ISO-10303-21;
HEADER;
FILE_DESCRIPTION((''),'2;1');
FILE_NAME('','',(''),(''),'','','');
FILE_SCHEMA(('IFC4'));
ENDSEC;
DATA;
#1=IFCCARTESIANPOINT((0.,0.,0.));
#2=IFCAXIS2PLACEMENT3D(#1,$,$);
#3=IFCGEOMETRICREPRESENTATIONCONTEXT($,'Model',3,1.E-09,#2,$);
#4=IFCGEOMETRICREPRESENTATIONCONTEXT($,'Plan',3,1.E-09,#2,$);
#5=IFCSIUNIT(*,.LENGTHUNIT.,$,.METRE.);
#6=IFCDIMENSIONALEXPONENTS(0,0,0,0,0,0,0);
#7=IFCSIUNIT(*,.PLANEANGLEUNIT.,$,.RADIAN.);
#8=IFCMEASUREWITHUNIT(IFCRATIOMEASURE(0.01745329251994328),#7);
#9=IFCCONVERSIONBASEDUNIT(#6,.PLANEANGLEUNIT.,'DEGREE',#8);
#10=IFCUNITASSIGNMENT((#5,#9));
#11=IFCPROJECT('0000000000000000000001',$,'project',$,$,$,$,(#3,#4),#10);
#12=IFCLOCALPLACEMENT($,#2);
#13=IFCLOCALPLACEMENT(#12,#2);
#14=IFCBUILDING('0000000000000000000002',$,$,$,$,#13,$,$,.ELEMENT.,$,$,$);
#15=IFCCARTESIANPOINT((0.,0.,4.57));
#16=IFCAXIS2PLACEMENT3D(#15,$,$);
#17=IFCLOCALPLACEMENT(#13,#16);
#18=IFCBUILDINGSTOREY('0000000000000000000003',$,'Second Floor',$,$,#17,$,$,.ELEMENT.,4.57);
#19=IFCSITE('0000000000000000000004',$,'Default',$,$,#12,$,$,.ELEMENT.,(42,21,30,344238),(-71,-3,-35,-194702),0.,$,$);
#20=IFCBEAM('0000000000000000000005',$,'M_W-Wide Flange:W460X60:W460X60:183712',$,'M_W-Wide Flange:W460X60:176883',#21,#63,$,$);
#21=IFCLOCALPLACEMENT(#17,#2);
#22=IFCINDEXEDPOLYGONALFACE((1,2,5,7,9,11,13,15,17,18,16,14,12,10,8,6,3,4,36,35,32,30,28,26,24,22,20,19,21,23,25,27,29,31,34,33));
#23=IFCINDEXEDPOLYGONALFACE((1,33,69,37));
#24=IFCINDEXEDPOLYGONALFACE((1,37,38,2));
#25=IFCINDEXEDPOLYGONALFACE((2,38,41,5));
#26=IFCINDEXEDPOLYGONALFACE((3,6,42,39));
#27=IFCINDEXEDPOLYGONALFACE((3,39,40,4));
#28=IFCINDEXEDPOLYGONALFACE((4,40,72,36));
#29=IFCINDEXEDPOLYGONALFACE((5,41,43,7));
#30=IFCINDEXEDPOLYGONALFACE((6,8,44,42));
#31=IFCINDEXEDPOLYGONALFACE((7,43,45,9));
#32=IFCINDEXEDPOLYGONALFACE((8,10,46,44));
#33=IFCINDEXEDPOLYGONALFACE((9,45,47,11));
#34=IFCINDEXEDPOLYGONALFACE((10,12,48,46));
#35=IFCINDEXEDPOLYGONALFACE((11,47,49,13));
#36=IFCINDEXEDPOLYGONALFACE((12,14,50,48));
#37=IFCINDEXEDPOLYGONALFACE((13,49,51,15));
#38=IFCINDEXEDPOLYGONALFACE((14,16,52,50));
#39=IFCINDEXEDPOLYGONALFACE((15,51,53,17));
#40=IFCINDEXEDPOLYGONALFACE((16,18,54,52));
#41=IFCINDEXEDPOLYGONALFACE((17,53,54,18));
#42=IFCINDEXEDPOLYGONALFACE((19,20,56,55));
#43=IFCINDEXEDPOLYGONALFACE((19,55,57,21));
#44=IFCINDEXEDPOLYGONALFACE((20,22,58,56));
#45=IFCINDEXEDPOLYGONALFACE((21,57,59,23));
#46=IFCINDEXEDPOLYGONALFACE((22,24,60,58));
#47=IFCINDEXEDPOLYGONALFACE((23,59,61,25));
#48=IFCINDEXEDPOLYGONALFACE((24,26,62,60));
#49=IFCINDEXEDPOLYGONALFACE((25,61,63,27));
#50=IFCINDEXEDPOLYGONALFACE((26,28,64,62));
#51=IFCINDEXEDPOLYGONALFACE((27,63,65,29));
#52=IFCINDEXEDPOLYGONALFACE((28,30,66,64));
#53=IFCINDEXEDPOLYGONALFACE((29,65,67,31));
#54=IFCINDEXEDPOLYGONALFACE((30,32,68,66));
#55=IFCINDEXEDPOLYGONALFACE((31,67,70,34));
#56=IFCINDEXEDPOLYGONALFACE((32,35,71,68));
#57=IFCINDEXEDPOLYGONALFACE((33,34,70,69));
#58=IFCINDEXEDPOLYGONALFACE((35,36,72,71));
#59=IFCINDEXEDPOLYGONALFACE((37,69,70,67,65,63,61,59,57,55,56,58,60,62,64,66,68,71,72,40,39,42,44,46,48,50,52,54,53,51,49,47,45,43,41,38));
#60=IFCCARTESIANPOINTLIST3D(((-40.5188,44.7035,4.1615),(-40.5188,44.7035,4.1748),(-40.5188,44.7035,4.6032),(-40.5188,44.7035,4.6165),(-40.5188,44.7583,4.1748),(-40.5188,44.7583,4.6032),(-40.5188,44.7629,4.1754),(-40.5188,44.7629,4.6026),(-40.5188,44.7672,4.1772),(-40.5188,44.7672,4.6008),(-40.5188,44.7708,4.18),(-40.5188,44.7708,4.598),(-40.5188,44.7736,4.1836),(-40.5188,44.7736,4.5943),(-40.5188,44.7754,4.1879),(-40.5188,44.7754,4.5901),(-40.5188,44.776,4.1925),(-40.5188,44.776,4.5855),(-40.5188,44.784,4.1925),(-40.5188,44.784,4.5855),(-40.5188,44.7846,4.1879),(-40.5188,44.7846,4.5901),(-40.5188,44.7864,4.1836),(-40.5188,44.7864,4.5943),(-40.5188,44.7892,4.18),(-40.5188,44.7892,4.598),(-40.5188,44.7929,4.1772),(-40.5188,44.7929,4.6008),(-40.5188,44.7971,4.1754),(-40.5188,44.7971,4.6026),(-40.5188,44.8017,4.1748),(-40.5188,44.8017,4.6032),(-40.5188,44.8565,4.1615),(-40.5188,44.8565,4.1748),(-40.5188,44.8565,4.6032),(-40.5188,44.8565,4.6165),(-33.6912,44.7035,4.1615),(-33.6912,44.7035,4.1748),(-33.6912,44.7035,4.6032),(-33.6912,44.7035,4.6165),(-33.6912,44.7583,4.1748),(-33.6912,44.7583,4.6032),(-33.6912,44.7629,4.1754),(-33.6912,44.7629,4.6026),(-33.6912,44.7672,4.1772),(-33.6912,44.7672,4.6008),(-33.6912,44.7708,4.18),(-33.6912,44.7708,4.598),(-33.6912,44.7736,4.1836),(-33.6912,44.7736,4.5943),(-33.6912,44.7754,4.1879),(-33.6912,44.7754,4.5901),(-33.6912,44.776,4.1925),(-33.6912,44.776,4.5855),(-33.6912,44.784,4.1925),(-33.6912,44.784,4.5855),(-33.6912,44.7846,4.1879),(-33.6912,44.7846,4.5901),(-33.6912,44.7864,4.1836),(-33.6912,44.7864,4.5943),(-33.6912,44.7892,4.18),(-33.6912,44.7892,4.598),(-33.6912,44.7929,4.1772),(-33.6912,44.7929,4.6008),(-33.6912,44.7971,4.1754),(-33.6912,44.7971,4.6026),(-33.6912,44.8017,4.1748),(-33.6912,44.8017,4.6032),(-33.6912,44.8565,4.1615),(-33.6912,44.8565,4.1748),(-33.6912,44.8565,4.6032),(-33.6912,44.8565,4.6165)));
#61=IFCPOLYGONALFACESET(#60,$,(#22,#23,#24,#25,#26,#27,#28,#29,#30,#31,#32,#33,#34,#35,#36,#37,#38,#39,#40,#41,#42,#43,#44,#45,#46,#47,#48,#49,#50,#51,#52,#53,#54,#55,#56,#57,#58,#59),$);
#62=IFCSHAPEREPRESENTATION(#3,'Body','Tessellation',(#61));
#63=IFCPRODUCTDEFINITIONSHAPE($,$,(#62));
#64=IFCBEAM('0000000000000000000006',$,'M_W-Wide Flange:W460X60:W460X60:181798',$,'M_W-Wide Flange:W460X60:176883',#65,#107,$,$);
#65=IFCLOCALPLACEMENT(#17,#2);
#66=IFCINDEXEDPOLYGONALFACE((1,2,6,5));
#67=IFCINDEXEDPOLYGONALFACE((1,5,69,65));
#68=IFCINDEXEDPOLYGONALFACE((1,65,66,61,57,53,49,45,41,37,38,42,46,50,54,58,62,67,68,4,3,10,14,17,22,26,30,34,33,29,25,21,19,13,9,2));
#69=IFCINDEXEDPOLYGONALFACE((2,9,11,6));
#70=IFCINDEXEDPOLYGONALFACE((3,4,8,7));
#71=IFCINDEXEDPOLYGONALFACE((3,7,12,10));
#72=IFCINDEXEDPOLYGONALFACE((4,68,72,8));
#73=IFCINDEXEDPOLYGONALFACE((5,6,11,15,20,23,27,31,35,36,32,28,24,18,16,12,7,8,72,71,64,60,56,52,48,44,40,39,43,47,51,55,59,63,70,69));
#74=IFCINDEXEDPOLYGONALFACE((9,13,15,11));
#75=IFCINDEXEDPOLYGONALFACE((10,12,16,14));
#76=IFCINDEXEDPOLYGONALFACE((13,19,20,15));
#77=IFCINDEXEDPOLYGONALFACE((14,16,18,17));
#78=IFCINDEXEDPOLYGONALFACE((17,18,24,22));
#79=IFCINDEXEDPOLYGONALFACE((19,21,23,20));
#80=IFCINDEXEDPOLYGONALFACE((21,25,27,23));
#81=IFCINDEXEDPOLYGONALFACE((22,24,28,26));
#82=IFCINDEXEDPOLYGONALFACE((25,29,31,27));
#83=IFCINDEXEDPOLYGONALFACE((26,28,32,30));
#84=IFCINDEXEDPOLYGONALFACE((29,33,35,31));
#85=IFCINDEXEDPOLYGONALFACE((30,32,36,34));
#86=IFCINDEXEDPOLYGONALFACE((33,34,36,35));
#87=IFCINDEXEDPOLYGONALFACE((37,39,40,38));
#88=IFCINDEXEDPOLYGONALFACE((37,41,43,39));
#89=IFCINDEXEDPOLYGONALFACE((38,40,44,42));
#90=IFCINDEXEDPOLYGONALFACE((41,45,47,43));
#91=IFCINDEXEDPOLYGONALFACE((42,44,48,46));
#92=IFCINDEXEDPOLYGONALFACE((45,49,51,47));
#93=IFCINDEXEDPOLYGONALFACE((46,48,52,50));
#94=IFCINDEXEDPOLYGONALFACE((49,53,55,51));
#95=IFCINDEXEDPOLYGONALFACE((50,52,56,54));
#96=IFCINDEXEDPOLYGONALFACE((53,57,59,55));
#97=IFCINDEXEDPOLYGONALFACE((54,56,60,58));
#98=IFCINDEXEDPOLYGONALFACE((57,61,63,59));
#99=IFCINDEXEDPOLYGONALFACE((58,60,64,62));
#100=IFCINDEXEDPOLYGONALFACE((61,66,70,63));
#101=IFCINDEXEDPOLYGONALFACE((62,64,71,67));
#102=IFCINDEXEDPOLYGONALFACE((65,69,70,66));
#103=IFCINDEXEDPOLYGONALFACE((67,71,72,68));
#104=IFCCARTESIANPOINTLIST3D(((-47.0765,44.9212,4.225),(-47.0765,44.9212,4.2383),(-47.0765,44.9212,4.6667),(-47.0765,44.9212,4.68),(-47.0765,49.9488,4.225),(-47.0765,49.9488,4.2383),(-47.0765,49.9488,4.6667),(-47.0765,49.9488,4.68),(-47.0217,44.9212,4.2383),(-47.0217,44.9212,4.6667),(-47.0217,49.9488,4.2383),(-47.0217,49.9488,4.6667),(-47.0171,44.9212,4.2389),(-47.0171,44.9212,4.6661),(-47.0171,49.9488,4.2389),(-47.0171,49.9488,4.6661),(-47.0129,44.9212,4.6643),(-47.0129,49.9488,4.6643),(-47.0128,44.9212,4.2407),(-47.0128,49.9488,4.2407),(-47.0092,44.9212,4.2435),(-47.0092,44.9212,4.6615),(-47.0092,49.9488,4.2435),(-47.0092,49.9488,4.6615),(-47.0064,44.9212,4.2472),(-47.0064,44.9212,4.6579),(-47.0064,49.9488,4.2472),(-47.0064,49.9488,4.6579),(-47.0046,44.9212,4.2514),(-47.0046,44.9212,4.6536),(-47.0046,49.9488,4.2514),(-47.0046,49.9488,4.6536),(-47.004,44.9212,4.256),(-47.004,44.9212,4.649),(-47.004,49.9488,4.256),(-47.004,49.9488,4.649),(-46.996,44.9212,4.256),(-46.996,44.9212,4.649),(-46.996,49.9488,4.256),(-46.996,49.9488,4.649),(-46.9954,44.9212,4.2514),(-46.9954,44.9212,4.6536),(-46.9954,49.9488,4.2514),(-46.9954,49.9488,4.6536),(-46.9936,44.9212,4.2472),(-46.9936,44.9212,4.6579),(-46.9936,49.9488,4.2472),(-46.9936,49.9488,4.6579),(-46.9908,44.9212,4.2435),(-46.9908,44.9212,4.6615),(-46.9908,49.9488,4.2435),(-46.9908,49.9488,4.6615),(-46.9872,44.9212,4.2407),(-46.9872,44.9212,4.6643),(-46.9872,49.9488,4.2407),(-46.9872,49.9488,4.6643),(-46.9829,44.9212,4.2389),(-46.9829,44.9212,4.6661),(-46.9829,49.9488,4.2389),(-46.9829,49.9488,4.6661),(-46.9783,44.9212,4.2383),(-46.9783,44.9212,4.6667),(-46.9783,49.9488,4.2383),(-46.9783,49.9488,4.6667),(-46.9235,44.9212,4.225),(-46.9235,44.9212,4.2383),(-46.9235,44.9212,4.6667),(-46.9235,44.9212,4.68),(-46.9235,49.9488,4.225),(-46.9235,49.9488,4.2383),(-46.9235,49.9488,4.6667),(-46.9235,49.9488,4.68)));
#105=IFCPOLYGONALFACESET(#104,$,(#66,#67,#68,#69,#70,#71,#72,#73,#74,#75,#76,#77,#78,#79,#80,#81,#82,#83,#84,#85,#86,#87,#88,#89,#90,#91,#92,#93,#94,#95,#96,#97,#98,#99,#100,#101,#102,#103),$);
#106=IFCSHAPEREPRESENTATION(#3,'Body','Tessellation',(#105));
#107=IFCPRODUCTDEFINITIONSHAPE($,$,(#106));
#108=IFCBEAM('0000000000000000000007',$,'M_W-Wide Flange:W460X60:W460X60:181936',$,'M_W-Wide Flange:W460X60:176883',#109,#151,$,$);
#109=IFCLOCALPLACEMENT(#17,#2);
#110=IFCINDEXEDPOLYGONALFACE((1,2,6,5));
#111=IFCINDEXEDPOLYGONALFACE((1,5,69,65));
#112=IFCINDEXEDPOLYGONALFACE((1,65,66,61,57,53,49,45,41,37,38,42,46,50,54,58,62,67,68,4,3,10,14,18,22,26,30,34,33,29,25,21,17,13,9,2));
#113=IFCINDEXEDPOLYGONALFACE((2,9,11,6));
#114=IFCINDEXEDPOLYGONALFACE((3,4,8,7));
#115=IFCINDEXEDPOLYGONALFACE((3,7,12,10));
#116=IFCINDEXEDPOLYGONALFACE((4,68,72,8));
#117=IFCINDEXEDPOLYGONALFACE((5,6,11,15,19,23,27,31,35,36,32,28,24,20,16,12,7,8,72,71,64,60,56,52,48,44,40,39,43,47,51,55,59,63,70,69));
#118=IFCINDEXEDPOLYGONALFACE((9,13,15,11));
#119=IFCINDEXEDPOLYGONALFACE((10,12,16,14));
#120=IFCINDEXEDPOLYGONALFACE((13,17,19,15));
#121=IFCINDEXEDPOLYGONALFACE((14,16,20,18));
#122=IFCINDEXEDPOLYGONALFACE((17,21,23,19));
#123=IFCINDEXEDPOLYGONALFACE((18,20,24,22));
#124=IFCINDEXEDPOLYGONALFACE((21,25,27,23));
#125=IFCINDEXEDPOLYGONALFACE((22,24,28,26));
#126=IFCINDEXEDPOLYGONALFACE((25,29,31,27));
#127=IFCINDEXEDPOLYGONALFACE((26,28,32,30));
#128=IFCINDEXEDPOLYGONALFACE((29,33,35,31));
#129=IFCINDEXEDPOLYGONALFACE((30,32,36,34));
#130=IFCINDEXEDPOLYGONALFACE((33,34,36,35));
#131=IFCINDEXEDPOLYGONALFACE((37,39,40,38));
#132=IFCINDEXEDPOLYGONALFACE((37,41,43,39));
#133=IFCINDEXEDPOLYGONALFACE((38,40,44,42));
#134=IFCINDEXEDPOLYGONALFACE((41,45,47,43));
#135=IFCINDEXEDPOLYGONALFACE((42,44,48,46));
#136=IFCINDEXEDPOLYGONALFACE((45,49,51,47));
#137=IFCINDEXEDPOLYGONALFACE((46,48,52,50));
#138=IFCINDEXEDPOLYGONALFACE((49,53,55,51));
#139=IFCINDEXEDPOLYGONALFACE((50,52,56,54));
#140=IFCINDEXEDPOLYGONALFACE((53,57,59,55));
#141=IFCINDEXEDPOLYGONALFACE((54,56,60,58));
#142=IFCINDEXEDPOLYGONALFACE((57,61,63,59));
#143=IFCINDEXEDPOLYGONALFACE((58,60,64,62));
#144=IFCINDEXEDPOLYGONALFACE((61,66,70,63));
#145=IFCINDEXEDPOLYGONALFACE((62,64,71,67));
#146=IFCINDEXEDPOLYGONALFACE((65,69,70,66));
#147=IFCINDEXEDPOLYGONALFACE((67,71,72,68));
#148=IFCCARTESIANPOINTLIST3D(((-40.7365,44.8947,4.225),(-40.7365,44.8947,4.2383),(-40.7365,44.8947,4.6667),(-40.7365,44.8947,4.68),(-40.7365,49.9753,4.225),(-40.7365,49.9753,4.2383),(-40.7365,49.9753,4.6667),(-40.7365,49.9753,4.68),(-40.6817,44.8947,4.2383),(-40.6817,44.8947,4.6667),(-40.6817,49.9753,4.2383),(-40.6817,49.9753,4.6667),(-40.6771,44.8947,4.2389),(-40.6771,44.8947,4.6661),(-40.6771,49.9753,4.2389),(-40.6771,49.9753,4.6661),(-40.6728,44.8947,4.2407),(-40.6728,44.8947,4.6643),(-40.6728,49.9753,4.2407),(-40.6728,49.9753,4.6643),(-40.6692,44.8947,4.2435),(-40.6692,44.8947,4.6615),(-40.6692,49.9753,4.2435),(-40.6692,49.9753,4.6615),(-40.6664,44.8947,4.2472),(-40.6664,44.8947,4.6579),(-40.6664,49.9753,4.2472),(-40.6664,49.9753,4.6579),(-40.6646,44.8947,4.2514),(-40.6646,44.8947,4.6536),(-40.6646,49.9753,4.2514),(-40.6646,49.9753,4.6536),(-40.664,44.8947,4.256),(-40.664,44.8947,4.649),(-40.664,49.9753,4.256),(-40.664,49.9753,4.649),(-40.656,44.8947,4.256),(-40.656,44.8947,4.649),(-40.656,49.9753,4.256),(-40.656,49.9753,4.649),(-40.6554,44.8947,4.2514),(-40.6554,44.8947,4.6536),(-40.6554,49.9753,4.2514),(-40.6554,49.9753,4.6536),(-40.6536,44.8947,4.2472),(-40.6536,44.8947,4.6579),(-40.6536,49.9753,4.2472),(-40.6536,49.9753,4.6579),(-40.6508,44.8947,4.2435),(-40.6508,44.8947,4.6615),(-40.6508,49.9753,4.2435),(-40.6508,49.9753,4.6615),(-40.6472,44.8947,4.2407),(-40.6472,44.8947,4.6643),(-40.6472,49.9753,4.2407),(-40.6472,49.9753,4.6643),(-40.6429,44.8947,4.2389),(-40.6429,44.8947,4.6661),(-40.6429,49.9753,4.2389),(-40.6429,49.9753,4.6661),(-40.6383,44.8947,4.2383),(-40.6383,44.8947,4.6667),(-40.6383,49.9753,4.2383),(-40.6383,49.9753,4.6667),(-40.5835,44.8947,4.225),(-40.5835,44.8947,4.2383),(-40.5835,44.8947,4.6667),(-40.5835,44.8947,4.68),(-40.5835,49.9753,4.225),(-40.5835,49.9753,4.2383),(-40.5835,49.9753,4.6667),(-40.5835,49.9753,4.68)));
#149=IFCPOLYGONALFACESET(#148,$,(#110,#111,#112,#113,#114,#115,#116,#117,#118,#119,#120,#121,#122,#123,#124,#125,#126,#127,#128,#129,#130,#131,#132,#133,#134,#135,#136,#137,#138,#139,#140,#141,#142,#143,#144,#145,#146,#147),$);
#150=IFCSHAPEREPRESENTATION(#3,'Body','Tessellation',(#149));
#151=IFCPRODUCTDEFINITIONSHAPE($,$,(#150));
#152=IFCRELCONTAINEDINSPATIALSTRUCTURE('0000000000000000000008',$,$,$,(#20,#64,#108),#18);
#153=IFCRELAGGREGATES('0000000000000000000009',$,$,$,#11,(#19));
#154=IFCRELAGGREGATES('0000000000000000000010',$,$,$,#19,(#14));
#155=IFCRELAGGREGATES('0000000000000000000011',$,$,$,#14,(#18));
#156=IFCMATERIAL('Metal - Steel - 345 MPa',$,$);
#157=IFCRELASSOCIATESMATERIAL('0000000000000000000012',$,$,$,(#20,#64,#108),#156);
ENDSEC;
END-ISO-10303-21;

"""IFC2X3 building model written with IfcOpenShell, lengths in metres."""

from ifc_helpers import new_model, entity, si_unit, converted_unit, frame, frame_2d, origin, place, context, project, spatial, polyline, circle_curve, parameter, trimmed, segment, composite_curve, outline, extrude, material, element, save


model = new_model("IFC2X3")

# Units and contexts
model_context = context("Model", 3, precision=1e-09, world=origin())
plan_context = context("Plan", 3, precision=1e-09, world=origin())
ifc_project = project(units=[si_unit("LENGTHUNIT", "METRE"), converted_unit("PLANEANGLEUNIT", "DEGREE", entity("IfcRatioMeasure", 0.01745329251994328), si_unit("PLANEANGLEUNIT", "RADIAN"), dimensions=[0, 0, 0, 0, 0, 0, 0])], contexts=[model_context, plan_context])

# Site, building, storey
site_placement = place(None, origin())
site = spatial("IfcSite", under=ifc_project, at=site_placement, Name="Default", CompositionType="ELEMENT", RefLatitude=(42, 21, 30, 344238), RefLongitude=(-71, -3, -35, -194702), RefElevation=0.0)
building_placement = place(site_placement, origin())
building = spatial("IfcBuilding", under=site, at=building_placement, CompositionType="ELEMENT")
storey_placement = place(building_placement, frame((0.0, 0.0, 4.57)))
storey = spatial("IfcBuildingStorey", under=building, at=storey_placement, Name="Second Floor", CompositionType="ELEMENT", Elevation=4.57)

# Shared definitions
ifc_material_1 = material(Name="Metal - Steel - 345 MPa")

# Beams
beam_1_placement = place(storey_placement, frame((-40.6573, 44.78, 4.6165), z_axis=(0.0, 0.0, 1.0), x_axis=(0.0, -1.0, 0.0)))
element("IfcBeam", 1, at=beam_1_placement, inside=storey, material=ifc_material_1, Name="M_W-Wide Flange:W460X60:W460X60:183712", ObjectType="M_W-Wide Flange:W460X60:176883", context=model_context, shape_type="SweptSolid", body=[
    extrude(outline(composite_curve([segment(polyline([(-0.0765, -0.2142), (-0.0765, -0.2275)]), True, "CONTINUOUS"), segment(polyline([(-0.0765, -0.2275), (0.0765, -0.2275)]), True, "CONTINUOUS"), segment(polyline([(0.0765, -0.2275), (0.0765, -0.2142)]), True, "CONTINUOUS"), segment(polyline([(0.0765, -0.2142), (0.0217, -0.2142)]), True, "CONTINUOUS"), segment(trimmed(circle_curve(frame_2d((0.0217, -0.1965), x_axis=(0.0, -1.0)), 0.0177), [parameter(270.0)], [parameter(360.0)], True, "PARAMETER"), False, "CONTINUOUS"), segment(polyline([(0.004, -0.1965), (0.004, 0.1965)]), True, "CONTINUOUS"), segment(trimmed(circle_curve(frame_2d((0.0217, 0.1965), x_axis=(-1.0, 0.0)), 0.0177), [parameter(270.0)], [parameter(360.0)], True, "PARAMETER"), False, "CONTINUOUS"), segment(polyline([(0.0217, 0.2142), (0.0765, 0.2142)]), True, "CONTINUOUS"), segment(polyline([(0.0765, 0.2142), (0.0765, 0.2275)]), True, "CONTINUOUS"), segment(polyline([(0.0765, 0.2275), (-0.0765, 0.2275)]), True, "CONTINUOUS"), segment(polyline([(-0.0765, 0.2275), (-0.0765, 0.2142)]), True, "CONTINUOUS"), segment(polyline([(-0.0765, 0.2142), (-0.0217, 0.2142)]), True, "CONTINUOUS"), segment(trimmed(circle_curve(frame_2d((-0.0217, 0.1965), x_axis=(0.0, 1.0)), 0.0177), [parameter(270.0)], [parameter(360.0)], True, "PARAMETER"), False, "CONTINUOUS"), segment(polyline([(-0.004, 0.1965), (-0.004, -0.1965)]), True, "CONTINUOUS"), segment(trimmed(circle_curve(frame_2d((-0.0217, -0.1965), x_axis=(1.0, 0.0)), 0.0177), [parameter(270.0)], [parameter(0.0)], True, "PARAMETER"), False, "CONTINUOUS"), segment(polyline([(-0.0217, -0.2142), (-0.0765, -0.2142)]), True, "CONTINUOUS")], self_intersect=False)), frame((0.0, 0.1385, -0.2275), z_axis=(0.0, -1.0, 0.0), x_axis=(1.0, 0.0, 0.0)), (0.0, 0.0, -1.0), 6.8276),
])
beam_2_placement = place(storey_placement, frame((-47.0, 50.0864, 4.68), z_axis=(0.0, 0.0, 1.0), x_axis=(-1.0, 0.0, 0.0)))
element("IfcBeam", 2, at=beam_2_placement, inside=storey, material=ifc_material_1, Name="M_W-Wide Flange:W460X60:W460X60:181798", ObjectType="M_W-Wide Flange:W460X60:176883", context=model_context, shape_type="SweptSolid", body=[
    extrude(outline(composite_curve([segment(polyline([(0.2142, -0.0765), (0.2275, -0.0765)]), True, "CONTINUOUS"), segment(polyline([(0.2275, -0.0765), (0.2275, 0.0765)]), True, "CONTINUOUS"), segment(polyline([(0.2275, 0.0765), (0.2142, 0.0765)]), True, "CONTINUOUS"), segment(polyline([(0.2142, 0.0765), (0.2142, 0.0217)]), True, "CONTINUOUS"), segment(trimmed(circle_curve(frame_2d((0.1965, 0.0217), x_axis=(1.0, 0.0)), 0.0177), [parameter(270.0)], [parameter(360.0)], True, "PARAMETER"), False, "CONTINUOUS"), segment(polyline([(0.1965, 0.004), (-0.1965, 0.004)]), True, "CONTINUOUS"), segment(trimmed(circle_curve(frame_2d((-0.1965, 0.0217), x_axis=(0.0, -1.0)), 0.0177), [parameter(270.0)], [parameter(360.0)], True, "PARAMETER"), False, "CONTINUOUS"), segment(polyline([(-0.2142, 0.0217), (-0.2142, 0.0765)]), True, "CONTINUOUS"), segment(polyline([(-0.2142, 0.0765), (-0.2275, 0.0765)]), True, "CONTINUOUS"), segment(polyline([(-0.2275, 0.0765), (-0.2275, -0.0765)]), True, "CONTINUOUS"), segment(polyline([(-0.2275, -0.0765), (-0.2142, -0.0765)]), True, "CONTINUOUS"), segment(polyline([(-0.2142, -0.0765), (-0.2142, -0.0217)]), True, "CONTINUOUS"), segment(trimmed(circle_curve(frame_2d((-0.1965, -0.0217), x_axis=(-1.0, 0.0)), 0.0177), [parameter(270.0)], [parameter(360.0)], True, "PARAMETER"), False, "CONTINUOUS"), segment(polyline([(-0.1965, -0.004), (0.1965, -0.004)]), True, "CONTINUOUS"), segment(trimmed(circle_curve(frame_2d((0.1965, -0.0217), x_axis=(0.0, 1.0)), 0.0177), [parameter(270.0)], [parameter(0.0)], True, "PARAMETER"), False, "CONTINUOUS"), segment(polyline([(0.2142, -0.0217), (0.2142, -0.0765)]), True, "CONTINUOUS")], self_intersect=False)), frame((0.0, 5.1652, -0.2275), z_axis=(0.0, -1.0, 0.0), x_axis=(0.0, 0.0, -1.0)), (0.0, 0.0, 1.0), 5.0276),
])
beam_3_placement = place(storey_placement, frame((-40.66, 44.7836, 4.68)))
element("IfcBeam", 3, at=beam_3_placement, inside=storey, material=ifc_material_1, Name="M_W-Wide Flange:W460X60:W460X60:181936", ObjectType="M_W-Wide Flange:W460X60:176883", context=model_context, shape_type="SweptSolid", body=[
    extrude(outline(composite_curve([segment(polyline([(-0.0765, -0.2142), (-0.0765, -0.2275)]), True, "CONTINUOUS"), segment(polyline([(-0.0765, -0.2275), (0.0765, -0.2275)]), True, "CONTINUOUS"), segment(polyline([(0.0765, -0.2275), (0.0765, -0.2142)]), True, "CONTINUOUS"), segment(polyline([(0.0765, -0.2142), (0.0217, -0.2142)]), True, "CONTINUOUS"), segment(trimmed(circle_curve(frame_2d((0.0217, -0.1965), x_axis=(0.0, -1.0)), 0.0177), [parameter(270.0)], [parameter(360.0)], True, "PARAMETER"), False, "CONTINUOUS"), segment(polyline([(0.004, -0.1965), (0.004, 0.1965)]), True, "CONTINUOUS"), segment(trimmed(circle_curve(frame_2d((0.0217, 0.1965), x_axis=(-1.0, 0.0)), 0.0177), [parameter(270.0)], [parameter(360.0)], True, "PARAMETER"), False, "CONTINUOUS"), segment(polyline([(0.0217, 0.2142), (0.0765, 0.2142)]), True, "CONTINUOUS"), segment(polyline([(0.0765, 0.2142), (0.0765, 0.2275)]), True, "CONTINUOUS"), segment(polyline([(0.0765, 0.2275), (-0.0765, 0.2275)]), True, "CONTINUOUS"), segment(polyline([(-0.0765, 0.2275), (-0.0765, 0.2142)]), True, "CONTINUOUS"), segment(polyline([(-0.0765, 0.2142), (-0.0217, 0.2142)]), True, "CONTINUOUS"), segment(trimmed(circle_curve(frame_2d((-0.0217, 0.1965), x_axis=(0.0, 1.0)), 0.0177), [parameter(270.0)], [parameter(360.0)], True, "PARAMETER"), False, "CONTINUOUS"), segment(polyline([(-0.004, 0.1965), (-0.004, -0.1965)]), True, "CONTINUOUS"), segment(trimmed(circle_curve(frame_2d((-0.0217, -0.1965), x_axis=(1.0, 0.0)), 0.0177), [parameter(270.0)], [parameter(0.0)], True, "PARAMETER"), False, "CONTINUOUS"), segment(polyline([(-0.0217, -0.2142), (-0.0765, -0.2142)]), True, "CONTINUOUS")], self_intersect=False)), frame((0.0, 0.1111, -0.2275), z_axis=(0.0, -1.0, 0.0), x_axis=(1.0, 0.0, 0.0)), (0.0, 0.0, -1.0), 5.0806),
])

save(model, "model.ifc")
